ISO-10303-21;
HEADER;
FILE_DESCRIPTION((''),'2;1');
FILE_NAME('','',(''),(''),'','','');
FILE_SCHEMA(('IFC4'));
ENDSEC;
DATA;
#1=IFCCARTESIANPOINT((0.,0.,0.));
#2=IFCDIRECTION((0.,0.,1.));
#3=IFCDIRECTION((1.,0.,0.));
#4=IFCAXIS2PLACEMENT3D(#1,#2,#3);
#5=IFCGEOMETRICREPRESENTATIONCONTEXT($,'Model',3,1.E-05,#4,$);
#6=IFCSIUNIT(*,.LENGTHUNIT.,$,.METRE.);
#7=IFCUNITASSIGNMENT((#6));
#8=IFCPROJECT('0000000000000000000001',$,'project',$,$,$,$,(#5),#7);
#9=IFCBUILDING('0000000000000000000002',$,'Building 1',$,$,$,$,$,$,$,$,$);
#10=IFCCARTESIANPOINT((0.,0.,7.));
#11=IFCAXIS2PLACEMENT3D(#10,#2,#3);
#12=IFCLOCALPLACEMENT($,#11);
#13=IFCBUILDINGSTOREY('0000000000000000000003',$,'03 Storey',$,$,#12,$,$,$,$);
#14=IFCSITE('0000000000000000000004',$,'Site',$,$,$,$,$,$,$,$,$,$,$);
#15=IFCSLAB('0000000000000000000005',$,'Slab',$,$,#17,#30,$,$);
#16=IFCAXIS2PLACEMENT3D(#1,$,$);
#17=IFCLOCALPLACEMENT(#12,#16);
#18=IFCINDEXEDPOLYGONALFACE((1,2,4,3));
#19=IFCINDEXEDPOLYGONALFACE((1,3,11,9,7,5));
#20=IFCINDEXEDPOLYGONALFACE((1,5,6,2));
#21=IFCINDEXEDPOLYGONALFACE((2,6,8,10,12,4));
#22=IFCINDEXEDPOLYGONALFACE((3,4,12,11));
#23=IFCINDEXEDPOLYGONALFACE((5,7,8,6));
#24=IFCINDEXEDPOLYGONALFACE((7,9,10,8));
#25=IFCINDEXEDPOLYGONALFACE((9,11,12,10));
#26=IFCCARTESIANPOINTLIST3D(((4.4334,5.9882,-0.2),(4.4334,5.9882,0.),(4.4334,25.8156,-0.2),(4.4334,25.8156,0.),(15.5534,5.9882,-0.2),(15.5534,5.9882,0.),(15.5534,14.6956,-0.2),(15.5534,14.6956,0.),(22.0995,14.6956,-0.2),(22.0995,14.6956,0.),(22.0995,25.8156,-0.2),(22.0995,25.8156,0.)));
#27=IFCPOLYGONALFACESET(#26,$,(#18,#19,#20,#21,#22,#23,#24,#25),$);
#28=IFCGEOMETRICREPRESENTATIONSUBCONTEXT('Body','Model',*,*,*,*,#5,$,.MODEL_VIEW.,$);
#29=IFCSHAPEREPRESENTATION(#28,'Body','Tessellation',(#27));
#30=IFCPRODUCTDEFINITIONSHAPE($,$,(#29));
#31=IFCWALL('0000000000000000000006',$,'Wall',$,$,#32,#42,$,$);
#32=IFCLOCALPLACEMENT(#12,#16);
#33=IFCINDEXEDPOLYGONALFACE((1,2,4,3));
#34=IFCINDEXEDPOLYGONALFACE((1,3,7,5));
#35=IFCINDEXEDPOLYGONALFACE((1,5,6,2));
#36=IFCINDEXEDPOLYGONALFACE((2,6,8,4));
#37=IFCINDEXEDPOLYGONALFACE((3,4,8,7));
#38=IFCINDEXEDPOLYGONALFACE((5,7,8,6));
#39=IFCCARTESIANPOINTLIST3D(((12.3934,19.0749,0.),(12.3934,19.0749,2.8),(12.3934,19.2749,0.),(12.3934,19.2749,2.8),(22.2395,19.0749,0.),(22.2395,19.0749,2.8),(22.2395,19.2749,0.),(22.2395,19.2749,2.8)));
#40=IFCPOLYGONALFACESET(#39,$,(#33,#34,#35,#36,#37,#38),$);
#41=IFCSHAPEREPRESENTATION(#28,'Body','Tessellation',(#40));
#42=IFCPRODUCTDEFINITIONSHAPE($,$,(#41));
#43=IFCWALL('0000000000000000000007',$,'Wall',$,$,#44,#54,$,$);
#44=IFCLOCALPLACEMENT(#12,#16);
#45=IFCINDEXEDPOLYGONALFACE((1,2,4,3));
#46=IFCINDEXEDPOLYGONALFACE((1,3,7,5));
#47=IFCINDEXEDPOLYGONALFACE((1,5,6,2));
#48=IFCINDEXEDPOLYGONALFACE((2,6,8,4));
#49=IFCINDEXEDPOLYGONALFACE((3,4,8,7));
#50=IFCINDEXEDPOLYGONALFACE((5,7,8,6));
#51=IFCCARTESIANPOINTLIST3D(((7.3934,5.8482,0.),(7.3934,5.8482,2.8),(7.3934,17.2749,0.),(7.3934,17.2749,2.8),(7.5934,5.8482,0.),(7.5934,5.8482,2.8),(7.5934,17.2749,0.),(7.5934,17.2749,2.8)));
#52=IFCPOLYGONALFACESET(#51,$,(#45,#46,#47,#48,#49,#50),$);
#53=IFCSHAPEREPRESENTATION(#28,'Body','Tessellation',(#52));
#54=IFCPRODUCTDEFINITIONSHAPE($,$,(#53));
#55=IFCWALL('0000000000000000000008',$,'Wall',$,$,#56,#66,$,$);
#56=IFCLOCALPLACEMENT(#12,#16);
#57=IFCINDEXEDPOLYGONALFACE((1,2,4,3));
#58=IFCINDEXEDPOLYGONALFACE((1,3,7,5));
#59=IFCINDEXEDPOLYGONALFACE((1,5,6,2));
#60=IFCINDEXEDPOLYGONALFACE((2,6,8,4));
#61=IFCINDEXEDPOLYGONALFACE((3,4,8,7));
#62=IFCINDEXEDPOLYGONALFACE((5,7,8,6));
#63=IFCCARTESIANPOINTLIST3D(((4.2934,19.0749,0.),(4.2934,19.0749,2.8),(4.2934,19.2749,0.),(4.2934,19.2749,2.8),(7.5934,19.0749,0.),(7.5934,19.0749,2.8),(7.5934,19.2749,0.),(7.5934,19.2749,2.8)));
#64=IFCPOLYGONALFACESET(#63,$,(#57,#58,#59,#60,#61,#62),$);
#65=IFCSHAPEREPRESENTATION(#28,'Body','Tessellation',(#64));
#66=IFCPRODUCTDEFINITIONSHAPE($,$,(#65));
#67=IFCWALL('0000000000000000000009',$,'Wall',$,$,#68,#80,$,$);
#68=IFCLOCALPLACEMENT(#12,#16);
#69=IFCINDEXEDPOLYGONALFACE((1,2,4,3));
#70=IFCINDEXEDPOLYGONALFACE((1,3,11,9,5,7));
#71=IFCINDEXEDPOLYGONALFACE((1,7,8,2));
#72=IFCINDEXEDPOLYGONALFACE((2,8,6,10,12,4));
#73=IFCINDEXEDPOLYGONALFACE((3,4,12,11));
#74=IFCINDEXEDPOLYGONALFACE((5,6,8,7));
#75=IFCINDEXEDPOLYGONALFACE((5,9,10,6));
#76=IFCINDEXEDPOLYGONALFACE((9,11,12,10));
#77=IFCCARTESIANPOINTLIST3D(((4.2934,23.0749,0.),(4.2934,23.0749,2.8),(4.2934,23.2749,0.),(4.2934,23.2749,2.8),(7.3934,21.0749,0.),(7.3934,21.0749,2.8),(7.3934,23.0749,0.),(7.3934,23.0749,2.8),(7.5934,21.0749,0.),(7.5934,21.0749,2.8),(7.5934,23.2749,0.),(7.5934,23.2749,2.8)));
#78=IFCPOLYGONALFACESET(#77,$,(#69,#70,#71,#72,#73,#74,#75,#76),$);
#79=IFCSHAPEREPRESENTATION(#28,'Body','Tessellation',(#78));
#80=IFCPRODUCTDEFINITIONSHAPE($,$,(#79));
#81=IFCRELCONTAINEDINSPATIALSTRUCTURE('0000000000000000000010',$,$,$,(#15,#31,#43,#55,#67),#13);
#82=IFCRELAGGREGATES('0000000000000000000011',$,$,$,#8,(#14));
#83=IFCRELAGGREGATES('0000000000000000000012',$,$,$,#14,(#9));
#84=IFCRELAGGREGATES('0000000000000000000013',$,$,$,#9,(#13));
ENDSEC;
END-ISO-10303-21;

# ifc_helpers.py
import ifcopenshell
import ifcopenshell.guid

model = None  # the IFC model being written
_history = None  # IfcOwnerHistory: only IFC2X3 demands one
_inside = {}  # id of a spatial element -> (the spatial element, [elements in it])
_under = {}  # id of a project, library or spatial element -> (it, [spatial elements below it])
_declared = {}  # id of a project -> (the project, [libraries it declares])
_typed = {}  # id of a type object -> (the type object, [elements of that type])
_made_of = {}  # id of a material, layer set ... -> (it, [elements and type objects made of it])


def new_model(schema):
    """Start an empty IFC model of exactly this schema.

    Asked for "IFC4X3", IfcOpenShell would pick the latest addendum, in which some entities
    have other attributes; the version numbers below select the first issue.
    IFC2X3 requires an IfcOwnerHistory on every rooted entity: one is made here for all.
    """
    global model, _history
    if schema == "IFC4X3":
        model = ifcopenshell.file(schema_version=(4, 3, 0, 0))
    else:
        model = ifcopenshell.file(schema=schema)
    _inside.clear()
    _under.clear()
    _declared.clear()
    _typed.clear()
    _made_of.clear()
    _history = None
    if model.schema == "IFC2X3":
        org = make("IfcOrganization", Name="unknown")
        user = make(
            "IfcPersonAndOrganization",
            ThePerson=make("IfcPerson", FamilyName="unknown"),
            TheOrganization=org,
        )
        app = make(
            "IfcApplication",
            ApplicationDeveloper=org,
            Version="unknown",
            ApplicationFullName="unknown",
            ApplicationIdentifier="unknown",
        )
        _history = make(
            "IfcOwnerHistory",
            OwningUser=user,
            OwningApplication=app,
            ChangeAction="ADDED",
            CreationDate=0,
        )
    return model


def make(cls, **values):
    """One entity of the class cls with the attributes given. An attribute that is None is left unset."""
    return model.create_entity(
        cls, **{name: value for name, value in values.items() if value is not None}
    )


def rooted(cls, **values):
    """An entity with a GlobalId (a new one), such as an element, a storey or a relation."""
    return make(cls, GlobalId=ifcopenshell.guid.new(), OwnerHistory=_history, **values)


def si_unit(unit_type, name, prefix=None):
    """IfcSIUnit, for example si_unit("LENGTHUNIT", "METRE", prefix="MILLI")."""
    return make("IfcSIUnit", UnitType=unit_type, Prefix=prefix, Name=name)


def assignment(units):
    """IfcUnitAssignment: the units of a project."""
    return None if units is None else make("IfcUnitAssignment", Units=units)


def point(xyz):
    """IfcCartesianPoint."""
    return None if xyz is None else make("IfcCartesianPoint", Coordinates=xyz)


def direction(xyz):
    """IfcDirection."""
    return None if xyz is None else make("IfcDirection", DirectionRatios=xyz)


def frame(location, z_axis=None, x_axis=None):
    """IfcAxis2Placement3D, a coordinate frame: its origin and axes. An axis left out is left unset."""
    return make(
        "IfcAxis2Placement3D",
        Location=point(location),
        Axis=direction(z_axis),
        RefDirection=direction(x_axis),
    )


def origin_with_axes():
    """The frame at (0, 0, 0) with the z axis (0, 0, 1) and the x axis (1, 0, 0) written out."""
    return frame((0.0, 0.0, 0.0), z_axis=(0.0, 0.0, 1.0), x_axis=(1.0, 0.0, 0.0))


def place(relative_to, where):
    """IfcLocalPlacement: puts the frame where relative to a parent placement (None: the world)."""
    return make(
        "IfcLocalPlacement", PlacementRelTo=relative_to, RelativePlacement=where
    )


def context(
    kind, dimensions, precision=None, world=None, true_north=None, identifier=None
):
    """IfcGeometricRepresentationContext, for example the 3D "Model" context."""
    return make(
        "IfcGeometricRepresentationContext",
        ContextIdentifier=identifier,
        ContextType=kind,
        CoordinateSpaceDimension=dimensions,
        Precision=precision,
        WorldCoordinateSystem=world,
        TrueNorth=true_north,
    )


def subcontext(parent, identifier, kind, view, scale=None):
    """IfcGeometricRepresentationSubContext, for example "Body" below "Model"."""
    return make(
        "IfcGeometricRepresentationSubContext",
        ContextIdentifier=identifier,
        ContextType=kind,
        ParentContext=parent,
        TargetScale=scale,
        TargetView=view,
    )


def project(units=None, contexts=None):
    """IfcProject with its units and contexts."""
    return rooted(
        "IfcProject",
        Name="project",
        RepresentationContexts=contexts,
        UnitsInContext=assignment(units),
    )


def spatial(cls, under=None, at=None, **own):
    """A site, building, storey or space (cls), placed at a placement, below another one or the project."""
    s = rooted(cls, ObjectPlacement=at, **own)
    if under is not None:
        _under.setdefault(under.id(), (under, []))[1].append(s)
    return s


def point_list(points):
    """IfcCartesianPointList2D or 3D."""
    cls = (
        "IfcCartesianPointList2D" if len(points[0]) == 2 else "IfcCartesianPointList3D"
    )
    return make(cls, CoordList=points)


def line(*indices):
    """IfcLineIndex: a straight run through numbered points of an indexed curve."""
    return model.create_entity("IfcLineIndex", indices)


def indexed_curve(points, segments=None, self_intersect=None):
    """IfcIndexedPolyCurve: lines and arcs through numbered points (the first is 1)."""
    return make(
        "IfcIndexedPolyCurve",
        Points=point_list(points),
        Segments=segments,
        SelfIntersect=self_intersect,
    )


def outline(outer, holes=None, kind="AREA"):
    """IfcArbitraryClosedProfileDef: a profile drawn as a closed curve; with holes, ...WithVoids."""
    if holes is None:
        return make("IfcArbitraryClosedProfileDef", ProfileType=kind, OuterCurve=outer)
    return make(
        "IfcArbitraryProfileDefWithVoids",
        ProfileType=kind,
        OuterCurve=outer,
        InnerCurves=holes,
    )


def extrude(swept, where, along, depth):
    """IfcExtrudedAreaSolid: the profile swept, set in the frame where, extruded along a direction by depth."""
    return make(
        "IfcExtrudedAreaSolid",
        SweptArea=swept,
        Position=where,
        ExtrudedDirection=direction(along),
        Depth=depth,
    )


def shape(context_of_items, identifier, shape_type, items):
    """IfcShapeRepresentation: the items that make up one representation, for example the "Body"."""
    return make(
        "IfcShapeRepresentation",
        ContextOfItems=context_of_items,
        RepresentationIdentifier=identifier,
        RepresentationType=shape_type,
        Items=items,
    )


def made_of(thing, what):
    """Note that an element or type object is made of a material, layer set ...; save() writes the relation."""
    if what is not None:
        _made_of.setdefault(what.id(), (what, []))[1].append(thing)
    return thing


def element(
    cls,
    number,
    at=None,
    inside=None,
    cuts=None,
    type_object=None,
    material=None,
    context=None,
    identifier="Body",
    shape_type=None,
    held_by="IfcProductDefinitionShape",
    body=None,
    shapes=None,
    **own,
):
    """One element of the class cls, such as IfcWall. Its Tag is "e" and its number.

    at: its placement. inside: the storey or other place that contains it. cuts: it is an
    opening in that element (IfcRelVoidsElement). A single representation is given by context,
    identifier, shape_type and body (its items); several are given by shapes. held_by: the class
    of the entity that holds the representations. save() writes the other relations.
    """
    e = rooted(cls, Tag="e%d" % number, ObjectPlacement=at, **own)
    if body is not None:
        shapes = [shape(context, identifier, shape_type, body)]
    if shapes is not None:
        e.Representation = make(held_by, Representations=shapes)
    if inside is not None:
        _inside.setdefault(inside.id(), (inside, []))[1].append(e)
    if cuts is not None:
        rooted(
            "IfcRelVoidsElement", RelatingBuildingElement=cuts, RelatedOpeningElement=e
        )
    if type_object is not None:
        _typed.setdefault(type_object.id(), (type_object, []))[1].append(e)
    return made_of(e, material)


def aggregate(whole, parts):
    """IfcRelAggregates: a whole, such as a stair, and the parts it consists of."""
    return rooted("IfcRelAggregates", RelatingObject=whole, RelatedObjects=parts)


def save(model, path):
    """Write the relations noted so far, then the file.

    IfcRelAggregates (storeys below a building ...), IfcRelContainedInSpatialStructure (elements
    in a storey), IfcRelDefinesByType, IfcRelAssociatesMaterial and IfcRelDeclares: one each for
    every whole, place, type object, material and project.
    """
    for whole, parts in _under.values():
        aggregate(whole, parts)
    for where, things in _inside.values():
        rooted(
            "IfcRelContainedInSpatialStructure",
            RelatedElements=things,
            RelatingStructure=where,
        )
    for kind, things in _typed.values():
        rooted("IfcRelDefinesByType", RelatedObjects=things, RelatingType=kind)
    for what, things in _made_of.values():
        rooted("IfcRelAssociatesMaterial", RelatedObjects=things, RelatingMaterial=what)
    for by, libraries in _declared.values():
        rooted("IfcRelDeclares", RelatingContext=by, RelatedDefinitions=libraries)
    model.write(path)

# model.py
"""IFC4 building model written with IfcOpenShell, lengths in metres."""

from ifc_helpers import new_model, si_unit, frame, origin_with_axes, place, context, subcontext, project, spatial, line, indexed_curve, outline, extrude, element, save


model = new_model("IFC4")

# Units and contexts
model_context = context("Model", 3, precision=1e-05, world=origin_with_axes())
body_context = subcontext(model_context, "Body", "Model", "MODEL_VIEW")
ifc_project = project(units=[si_unit("LENGTHUNIT", "METRE")], contexts=[model_context])

# Site, building, storey
site = spatial("IfcSite", under=ifc_project, Name="Site")
building = spatial("IfcBuilding", under=site, Name="Building 1")
storey_placement = place(None, frame((0.0, 0.0, 7.0), z_axis=(0.0, 0.0, 1.0), x_axis=(1.0, 0.0, 0.0)))
storey = spatial("IfcBuildingStorey", under=building, at=storey_placement, Name="03 Storey")

# Slab
slab_placement = place(storey_placement, origin_with_axes())
element("IfcSlab", 1, at=slab_placement, inside=storey, Name="Slab", context=body_context, shape_type="SweptSolid", body=[
    extrude(outline(indexed_curve([(15.5534, 14.6956), (22.0995, 14.6956), (22.0995, 25.8156), (4.4334, 25.8156), (4.4334, 5.9882), (15.5534, 5.9882)], segments=[line(1, 2), line(2, 3), line(3, 4), line(4, 5), line(5, 6)])), origin_with_axes(), (0.0, 0.0, -1.0), 0.2),
])

# Walls
wall_1_placement = place(storey_placement, origin_with_axes())
element("IfcWall", 2, at=wall_1_placement, inside=storey, Name="Wall", context=body_context, shape_type="SweptSolid", body=[
    extrude(outline(indexed_curve([(22.2395, 19.2749), (12.3934, 19.2749), (12.3934, 19.0749), (22.2395, 19.0749)], segments=[line(1, 2), line(2, 3), line(3, 4)])), origin_with_axes(), (0.0, 0.0, 1.0), 2.8),
])
wall_2_placement = place(storey_placement, origin_with_axes())
element("IfcWall", 3, at=wall_2_placement, inside=storey, Name="Wall", context=body_context, shape_type="SweptSolid", body=[
    extrude(outline(indexed_curve([(7.5934, 17.2749), (7.3934, 17.2749), (7.3934, 5.8482), (7.5934, 5.8482)], segments=[line(1, 2), line(2, 3), line(3, 4)])), origin_with_axes(), (0.0, 0.0, 1.0), 2.8),
])
wall_3_placement = place(storey_placement, origin_with_axes())
element("IfcWall", 4, at=wall_3_placement, inside=storey, Name="Wall", context=body_context, shape_type="SweptSolid", body=[
    extrude(outline(indexed_curve([(7.5934, 19.2749), (4.2934, 19.2749), (4.2934, 19.0749), (7.5934, 19.0749)], segments=[line(1, 2), line(2, 3), line(3, 4)])), origin_with_axes(), (0.0, 0.0, 1.0), 2.8),
])
wall_4_placement = place(storey_placement, origin_with_axes())
element("IfcWall", 5, at=wall_4_placement, inside=storey, Name="Wall", context=body_context, shape_type="SweptSolid", body=[
    extrude(outline(indexed_curve([(7.5934, 23.2749), (4.2934, 23.2749), (4.2934, 23.0749), (7.3934, 23.0749), (7.3934, 21.0749), (7.5934, 21.0749)], segments=[line(1, 2), line(2, 3), line(3, 4), line(4, 5), line(5, 6)])), origin_with_axes(), (0.0, 0.0, 1.0), 2.8),
])

save(model, "model.ifc")
